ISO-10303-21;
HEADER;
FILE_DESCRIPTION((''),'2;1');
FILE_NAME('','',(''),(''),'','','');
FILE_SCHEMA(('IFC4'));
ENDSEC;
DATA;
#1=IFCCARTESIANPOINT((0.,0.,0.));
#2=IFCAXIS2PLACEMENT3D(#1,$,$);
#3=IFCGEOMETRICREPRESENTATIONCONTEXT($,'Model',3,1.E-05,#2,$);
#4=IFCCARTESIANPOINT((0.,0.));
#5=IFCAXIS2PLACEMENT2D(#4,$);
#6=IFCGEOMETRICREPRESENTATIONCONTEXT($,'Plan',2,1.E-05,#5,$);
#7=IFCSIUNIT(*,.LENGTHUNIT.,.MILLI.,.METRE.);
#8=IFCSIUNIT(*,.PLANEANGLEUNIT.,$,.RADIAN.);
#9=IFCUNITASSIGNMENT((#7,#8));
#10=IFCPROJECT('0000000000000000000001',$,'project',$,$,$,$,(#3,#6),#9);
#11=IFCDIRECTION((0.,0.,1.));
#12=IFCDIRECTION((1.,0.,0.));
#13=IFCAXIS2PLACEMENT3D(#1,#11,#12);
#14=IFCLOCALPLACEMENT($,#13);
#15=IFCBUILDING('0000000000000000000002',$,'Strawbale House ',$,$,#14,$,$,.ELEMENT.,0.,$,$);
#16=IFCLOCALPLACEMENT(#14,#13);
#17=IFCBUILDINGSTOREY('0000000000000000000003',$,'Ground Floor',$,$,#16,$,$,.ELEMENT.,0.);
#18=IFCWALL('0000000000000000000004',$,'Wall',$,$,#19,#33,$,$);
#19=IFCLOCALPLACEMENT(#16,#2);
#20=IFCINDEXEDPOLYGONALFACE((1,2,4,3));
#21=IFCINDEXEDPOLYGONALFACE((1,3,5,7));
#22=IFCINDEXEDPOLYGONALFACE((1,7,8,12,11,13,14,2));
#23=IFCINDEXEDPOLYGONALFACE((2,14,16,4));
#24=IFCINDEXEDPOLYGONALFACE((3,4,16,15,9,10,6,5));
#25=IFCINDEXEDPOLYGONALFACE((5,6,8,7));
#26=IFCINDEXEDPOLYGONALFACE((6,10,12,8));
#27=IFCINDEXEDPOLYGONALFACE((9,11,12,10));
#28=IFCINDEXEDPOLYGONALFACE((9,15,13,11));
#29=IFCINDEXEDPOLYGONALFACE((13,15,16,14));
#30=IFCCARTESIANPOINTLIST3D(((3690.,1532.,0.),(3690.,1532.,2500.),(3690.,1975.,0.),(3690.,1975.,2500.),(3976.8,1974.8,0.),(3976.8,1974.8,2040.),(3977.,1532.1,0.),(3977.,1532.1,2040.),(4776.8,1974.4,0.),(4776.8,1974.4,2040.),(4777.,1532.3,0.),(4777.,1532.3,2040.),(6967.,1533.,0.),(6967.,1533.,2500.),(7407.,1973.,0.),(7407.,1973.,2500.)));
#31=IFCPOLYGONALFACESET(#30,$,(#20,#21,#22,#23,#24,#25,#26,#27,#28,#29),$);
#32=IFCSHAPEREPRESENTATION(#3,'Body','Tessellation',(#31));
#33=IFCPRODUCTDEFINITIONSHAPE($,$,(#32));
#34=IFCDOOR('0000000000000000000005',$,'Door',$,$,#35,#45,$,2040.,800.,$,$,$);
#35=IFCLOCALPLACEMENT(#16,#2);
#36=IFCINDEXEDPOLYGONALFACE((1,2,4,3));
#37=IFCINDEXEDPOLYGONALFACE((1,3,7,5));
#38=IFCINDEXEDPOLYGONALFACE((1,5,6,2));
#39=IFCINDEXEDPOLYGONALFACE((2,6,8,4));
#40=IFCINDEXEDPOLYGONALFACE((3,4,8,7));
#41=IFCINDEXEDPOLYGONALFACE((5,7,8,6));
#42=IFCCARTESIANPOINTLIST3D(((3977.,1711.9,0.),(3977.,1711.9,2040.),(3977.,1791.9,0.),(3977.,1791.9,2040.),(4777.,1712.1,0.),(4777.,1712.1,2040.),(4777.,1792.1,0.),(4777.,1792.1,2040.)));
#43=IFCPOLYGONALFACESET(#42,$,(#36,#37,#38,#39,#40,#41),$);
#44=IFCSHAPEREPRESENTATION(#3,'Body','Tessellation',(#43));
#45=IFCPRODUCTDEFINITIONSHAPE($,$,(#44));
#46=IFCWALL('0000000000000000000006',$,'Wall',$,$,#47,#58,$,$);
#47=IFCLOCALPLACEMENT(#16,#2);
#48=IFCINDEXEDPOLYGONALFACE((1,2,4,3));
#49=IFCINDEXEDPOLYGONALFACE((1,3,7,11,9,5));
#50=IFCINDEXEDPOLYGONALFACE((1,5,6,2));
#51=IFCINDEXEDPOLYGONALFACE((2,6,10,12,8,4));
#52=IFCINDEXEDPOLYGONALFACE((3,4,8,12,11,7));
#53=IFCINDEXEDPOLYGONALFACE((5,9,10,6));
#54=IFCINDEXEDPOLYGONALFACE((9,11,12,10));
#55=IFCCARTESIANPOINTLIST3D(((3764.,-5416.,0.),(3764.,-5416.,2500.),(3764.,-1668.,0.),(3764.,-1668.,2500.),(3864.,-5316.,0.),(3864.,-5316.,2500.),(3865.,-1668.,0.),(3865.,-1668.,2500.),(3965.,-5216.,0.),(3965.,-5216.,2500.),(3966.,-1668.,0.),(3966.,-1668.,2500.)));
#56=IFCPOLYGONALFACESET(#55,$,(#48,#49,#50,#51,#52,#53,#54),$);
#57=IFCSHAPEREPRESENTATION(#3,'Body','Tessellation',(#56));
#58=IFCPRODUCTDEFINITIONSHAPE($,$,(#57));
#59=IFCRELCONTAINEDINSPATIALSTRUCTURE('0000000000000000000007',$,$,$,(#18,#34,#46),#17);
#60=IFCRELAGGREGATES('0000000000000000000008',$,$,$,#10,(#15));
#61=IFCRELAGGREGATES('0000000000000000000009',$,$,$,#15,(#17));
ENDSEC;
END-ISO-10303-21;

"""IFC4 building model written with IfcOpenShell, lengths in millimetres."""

from ifc_helpers import new_model, si_unit, frame, origin, origin_with_axes, origin_2d, origin_2d_with_axis, place, context, project, spatial, polyline, rectangle, outline, extrude, element, fill, save


model = new_model("IFC4")

# Units and contexts
model_context = context("Model", 3, precision=1e-05, world=origin())
plan_context = context("Plan", 2, precision=1e-05, world=origin_2d())
ifc_project = project(units=[si_unit("LENGTHUNIT", "METRE", prefix="MILLI"), si_unit("PLANEANGLEUNIT", "RADIAN")], contexts=[model_context, plan_context])

# Building, storey
building_placement = place(None, origin_with_axes())
building = spatial("IfcBuilding", under=ifc_project, at=building_placement, Name="Strawbale House ", CompositionType="ELEMENT", ElevationOfRefHeight=0.0)
storey_placement = place(building_placement, origin_with_axes())
storey = spatial("IfcBuildingStorey", under=building, at=storey_placement, Name="Ground Floor", CompositionType="ELEMENT", Elevation=0.0)

# Wall, opening, door
wall_1_placement = place(storey_placement, origin_with_axes())
wall_1 = element("IfcWall", 1, at=wall_1_placement, inside=storey, Name="Wall", context=model_context, shape_type="SweptSolid", body=[
    extrude(outline(polyline([(7187.0, 1753.0, 0.0), (6967.0, 1533.0, 0.0), (3690.0, 1532.0, 0.0), (3690.0, 1753.0, 0.0), (3690.0, 1975.0, 0.0), (7407.0, 1973.0, 0.0), (7187.0, 1753.0, 0.0)])), origin_with_axes(), (0.0, 0.0, 1.0), 2500.0),
])
opening_1_placement = place(wall_1_placement, frame((4377.0, 1432.0, 1020.0), z_axis=(0.0, 0.0, 1.0), x_axis=(1.0, 0.0, 0.0)))
opening_1 = element("IfcOpeningElement", 2, at=opening_1_placement, cuts=wall_1, PredefinedType="OPENING", context=model_context, shape_type="SweptSolid", body=[
    extrude(rectangle(XDim=800.0, YDim=2040.0, at=origin_2d_with_axis()), frame((0.0, 0.0, 0.0), z_axis=(-1.0, 3277.0, 0.0), x_axis=(-3277.0, -1.0, 0.0)), (0.0, 0.0, 1.0), 640.2),
])
door_1_placement = place(opening_1_placement, frame((0.0, 280.0, 0.0), z_axis=(0.0, 0.0, 1.0), x_axis=(1.0, 0.0, 0.0)))
door_1 = element("IfcDoor", 3, at=door_1_placement, inside=storey, Name="Door", OverallHeight=2040.0, OverallWidth=800.0, context=model_context, shape_type="SweptSolid", body=[
    extrude(outline(polyline([(400.0, 1020.0, 0.0), (400.0, -1020.0, 0.0), (-400.0, -1020.0, 0.0), (-400.0, 1020.0, 0.0), (400.0, 1020.0, 0.0)])), frame((0.0, 0.0, 0.0), z_axis=(-1.0, 3277.0, 0.0), x_axis=(-3277.0, -1.0, 0.0)), (0.0, 0.0, 1.0), 80.0),
])
fill(opening_1, door_1)

# Wall
wall_2_placement = place(storey_placement, origin_with_axes())
element("IfcWall", 4, at=wall_2_placement, inside=storey, Name="Wall", context=model_context, shape_type="SweptSolid", body=[
    extrude(outline(polyline([(3865.0, -1668.0, 0.0), (3966.0, -1668.0, 0.0), (3965.0, -5216.0, 0.0), (3864.0, -5316.0, 0.0), (3764.0, -5416.0, 0.0), (3764.0, -1668.0, 0.0), (3865.0, -1668.0, 0.0)])), origin_with_axes(), (0.0, 0.0, 1.0), 2500.0),
])

save(model, "model.ifc")
